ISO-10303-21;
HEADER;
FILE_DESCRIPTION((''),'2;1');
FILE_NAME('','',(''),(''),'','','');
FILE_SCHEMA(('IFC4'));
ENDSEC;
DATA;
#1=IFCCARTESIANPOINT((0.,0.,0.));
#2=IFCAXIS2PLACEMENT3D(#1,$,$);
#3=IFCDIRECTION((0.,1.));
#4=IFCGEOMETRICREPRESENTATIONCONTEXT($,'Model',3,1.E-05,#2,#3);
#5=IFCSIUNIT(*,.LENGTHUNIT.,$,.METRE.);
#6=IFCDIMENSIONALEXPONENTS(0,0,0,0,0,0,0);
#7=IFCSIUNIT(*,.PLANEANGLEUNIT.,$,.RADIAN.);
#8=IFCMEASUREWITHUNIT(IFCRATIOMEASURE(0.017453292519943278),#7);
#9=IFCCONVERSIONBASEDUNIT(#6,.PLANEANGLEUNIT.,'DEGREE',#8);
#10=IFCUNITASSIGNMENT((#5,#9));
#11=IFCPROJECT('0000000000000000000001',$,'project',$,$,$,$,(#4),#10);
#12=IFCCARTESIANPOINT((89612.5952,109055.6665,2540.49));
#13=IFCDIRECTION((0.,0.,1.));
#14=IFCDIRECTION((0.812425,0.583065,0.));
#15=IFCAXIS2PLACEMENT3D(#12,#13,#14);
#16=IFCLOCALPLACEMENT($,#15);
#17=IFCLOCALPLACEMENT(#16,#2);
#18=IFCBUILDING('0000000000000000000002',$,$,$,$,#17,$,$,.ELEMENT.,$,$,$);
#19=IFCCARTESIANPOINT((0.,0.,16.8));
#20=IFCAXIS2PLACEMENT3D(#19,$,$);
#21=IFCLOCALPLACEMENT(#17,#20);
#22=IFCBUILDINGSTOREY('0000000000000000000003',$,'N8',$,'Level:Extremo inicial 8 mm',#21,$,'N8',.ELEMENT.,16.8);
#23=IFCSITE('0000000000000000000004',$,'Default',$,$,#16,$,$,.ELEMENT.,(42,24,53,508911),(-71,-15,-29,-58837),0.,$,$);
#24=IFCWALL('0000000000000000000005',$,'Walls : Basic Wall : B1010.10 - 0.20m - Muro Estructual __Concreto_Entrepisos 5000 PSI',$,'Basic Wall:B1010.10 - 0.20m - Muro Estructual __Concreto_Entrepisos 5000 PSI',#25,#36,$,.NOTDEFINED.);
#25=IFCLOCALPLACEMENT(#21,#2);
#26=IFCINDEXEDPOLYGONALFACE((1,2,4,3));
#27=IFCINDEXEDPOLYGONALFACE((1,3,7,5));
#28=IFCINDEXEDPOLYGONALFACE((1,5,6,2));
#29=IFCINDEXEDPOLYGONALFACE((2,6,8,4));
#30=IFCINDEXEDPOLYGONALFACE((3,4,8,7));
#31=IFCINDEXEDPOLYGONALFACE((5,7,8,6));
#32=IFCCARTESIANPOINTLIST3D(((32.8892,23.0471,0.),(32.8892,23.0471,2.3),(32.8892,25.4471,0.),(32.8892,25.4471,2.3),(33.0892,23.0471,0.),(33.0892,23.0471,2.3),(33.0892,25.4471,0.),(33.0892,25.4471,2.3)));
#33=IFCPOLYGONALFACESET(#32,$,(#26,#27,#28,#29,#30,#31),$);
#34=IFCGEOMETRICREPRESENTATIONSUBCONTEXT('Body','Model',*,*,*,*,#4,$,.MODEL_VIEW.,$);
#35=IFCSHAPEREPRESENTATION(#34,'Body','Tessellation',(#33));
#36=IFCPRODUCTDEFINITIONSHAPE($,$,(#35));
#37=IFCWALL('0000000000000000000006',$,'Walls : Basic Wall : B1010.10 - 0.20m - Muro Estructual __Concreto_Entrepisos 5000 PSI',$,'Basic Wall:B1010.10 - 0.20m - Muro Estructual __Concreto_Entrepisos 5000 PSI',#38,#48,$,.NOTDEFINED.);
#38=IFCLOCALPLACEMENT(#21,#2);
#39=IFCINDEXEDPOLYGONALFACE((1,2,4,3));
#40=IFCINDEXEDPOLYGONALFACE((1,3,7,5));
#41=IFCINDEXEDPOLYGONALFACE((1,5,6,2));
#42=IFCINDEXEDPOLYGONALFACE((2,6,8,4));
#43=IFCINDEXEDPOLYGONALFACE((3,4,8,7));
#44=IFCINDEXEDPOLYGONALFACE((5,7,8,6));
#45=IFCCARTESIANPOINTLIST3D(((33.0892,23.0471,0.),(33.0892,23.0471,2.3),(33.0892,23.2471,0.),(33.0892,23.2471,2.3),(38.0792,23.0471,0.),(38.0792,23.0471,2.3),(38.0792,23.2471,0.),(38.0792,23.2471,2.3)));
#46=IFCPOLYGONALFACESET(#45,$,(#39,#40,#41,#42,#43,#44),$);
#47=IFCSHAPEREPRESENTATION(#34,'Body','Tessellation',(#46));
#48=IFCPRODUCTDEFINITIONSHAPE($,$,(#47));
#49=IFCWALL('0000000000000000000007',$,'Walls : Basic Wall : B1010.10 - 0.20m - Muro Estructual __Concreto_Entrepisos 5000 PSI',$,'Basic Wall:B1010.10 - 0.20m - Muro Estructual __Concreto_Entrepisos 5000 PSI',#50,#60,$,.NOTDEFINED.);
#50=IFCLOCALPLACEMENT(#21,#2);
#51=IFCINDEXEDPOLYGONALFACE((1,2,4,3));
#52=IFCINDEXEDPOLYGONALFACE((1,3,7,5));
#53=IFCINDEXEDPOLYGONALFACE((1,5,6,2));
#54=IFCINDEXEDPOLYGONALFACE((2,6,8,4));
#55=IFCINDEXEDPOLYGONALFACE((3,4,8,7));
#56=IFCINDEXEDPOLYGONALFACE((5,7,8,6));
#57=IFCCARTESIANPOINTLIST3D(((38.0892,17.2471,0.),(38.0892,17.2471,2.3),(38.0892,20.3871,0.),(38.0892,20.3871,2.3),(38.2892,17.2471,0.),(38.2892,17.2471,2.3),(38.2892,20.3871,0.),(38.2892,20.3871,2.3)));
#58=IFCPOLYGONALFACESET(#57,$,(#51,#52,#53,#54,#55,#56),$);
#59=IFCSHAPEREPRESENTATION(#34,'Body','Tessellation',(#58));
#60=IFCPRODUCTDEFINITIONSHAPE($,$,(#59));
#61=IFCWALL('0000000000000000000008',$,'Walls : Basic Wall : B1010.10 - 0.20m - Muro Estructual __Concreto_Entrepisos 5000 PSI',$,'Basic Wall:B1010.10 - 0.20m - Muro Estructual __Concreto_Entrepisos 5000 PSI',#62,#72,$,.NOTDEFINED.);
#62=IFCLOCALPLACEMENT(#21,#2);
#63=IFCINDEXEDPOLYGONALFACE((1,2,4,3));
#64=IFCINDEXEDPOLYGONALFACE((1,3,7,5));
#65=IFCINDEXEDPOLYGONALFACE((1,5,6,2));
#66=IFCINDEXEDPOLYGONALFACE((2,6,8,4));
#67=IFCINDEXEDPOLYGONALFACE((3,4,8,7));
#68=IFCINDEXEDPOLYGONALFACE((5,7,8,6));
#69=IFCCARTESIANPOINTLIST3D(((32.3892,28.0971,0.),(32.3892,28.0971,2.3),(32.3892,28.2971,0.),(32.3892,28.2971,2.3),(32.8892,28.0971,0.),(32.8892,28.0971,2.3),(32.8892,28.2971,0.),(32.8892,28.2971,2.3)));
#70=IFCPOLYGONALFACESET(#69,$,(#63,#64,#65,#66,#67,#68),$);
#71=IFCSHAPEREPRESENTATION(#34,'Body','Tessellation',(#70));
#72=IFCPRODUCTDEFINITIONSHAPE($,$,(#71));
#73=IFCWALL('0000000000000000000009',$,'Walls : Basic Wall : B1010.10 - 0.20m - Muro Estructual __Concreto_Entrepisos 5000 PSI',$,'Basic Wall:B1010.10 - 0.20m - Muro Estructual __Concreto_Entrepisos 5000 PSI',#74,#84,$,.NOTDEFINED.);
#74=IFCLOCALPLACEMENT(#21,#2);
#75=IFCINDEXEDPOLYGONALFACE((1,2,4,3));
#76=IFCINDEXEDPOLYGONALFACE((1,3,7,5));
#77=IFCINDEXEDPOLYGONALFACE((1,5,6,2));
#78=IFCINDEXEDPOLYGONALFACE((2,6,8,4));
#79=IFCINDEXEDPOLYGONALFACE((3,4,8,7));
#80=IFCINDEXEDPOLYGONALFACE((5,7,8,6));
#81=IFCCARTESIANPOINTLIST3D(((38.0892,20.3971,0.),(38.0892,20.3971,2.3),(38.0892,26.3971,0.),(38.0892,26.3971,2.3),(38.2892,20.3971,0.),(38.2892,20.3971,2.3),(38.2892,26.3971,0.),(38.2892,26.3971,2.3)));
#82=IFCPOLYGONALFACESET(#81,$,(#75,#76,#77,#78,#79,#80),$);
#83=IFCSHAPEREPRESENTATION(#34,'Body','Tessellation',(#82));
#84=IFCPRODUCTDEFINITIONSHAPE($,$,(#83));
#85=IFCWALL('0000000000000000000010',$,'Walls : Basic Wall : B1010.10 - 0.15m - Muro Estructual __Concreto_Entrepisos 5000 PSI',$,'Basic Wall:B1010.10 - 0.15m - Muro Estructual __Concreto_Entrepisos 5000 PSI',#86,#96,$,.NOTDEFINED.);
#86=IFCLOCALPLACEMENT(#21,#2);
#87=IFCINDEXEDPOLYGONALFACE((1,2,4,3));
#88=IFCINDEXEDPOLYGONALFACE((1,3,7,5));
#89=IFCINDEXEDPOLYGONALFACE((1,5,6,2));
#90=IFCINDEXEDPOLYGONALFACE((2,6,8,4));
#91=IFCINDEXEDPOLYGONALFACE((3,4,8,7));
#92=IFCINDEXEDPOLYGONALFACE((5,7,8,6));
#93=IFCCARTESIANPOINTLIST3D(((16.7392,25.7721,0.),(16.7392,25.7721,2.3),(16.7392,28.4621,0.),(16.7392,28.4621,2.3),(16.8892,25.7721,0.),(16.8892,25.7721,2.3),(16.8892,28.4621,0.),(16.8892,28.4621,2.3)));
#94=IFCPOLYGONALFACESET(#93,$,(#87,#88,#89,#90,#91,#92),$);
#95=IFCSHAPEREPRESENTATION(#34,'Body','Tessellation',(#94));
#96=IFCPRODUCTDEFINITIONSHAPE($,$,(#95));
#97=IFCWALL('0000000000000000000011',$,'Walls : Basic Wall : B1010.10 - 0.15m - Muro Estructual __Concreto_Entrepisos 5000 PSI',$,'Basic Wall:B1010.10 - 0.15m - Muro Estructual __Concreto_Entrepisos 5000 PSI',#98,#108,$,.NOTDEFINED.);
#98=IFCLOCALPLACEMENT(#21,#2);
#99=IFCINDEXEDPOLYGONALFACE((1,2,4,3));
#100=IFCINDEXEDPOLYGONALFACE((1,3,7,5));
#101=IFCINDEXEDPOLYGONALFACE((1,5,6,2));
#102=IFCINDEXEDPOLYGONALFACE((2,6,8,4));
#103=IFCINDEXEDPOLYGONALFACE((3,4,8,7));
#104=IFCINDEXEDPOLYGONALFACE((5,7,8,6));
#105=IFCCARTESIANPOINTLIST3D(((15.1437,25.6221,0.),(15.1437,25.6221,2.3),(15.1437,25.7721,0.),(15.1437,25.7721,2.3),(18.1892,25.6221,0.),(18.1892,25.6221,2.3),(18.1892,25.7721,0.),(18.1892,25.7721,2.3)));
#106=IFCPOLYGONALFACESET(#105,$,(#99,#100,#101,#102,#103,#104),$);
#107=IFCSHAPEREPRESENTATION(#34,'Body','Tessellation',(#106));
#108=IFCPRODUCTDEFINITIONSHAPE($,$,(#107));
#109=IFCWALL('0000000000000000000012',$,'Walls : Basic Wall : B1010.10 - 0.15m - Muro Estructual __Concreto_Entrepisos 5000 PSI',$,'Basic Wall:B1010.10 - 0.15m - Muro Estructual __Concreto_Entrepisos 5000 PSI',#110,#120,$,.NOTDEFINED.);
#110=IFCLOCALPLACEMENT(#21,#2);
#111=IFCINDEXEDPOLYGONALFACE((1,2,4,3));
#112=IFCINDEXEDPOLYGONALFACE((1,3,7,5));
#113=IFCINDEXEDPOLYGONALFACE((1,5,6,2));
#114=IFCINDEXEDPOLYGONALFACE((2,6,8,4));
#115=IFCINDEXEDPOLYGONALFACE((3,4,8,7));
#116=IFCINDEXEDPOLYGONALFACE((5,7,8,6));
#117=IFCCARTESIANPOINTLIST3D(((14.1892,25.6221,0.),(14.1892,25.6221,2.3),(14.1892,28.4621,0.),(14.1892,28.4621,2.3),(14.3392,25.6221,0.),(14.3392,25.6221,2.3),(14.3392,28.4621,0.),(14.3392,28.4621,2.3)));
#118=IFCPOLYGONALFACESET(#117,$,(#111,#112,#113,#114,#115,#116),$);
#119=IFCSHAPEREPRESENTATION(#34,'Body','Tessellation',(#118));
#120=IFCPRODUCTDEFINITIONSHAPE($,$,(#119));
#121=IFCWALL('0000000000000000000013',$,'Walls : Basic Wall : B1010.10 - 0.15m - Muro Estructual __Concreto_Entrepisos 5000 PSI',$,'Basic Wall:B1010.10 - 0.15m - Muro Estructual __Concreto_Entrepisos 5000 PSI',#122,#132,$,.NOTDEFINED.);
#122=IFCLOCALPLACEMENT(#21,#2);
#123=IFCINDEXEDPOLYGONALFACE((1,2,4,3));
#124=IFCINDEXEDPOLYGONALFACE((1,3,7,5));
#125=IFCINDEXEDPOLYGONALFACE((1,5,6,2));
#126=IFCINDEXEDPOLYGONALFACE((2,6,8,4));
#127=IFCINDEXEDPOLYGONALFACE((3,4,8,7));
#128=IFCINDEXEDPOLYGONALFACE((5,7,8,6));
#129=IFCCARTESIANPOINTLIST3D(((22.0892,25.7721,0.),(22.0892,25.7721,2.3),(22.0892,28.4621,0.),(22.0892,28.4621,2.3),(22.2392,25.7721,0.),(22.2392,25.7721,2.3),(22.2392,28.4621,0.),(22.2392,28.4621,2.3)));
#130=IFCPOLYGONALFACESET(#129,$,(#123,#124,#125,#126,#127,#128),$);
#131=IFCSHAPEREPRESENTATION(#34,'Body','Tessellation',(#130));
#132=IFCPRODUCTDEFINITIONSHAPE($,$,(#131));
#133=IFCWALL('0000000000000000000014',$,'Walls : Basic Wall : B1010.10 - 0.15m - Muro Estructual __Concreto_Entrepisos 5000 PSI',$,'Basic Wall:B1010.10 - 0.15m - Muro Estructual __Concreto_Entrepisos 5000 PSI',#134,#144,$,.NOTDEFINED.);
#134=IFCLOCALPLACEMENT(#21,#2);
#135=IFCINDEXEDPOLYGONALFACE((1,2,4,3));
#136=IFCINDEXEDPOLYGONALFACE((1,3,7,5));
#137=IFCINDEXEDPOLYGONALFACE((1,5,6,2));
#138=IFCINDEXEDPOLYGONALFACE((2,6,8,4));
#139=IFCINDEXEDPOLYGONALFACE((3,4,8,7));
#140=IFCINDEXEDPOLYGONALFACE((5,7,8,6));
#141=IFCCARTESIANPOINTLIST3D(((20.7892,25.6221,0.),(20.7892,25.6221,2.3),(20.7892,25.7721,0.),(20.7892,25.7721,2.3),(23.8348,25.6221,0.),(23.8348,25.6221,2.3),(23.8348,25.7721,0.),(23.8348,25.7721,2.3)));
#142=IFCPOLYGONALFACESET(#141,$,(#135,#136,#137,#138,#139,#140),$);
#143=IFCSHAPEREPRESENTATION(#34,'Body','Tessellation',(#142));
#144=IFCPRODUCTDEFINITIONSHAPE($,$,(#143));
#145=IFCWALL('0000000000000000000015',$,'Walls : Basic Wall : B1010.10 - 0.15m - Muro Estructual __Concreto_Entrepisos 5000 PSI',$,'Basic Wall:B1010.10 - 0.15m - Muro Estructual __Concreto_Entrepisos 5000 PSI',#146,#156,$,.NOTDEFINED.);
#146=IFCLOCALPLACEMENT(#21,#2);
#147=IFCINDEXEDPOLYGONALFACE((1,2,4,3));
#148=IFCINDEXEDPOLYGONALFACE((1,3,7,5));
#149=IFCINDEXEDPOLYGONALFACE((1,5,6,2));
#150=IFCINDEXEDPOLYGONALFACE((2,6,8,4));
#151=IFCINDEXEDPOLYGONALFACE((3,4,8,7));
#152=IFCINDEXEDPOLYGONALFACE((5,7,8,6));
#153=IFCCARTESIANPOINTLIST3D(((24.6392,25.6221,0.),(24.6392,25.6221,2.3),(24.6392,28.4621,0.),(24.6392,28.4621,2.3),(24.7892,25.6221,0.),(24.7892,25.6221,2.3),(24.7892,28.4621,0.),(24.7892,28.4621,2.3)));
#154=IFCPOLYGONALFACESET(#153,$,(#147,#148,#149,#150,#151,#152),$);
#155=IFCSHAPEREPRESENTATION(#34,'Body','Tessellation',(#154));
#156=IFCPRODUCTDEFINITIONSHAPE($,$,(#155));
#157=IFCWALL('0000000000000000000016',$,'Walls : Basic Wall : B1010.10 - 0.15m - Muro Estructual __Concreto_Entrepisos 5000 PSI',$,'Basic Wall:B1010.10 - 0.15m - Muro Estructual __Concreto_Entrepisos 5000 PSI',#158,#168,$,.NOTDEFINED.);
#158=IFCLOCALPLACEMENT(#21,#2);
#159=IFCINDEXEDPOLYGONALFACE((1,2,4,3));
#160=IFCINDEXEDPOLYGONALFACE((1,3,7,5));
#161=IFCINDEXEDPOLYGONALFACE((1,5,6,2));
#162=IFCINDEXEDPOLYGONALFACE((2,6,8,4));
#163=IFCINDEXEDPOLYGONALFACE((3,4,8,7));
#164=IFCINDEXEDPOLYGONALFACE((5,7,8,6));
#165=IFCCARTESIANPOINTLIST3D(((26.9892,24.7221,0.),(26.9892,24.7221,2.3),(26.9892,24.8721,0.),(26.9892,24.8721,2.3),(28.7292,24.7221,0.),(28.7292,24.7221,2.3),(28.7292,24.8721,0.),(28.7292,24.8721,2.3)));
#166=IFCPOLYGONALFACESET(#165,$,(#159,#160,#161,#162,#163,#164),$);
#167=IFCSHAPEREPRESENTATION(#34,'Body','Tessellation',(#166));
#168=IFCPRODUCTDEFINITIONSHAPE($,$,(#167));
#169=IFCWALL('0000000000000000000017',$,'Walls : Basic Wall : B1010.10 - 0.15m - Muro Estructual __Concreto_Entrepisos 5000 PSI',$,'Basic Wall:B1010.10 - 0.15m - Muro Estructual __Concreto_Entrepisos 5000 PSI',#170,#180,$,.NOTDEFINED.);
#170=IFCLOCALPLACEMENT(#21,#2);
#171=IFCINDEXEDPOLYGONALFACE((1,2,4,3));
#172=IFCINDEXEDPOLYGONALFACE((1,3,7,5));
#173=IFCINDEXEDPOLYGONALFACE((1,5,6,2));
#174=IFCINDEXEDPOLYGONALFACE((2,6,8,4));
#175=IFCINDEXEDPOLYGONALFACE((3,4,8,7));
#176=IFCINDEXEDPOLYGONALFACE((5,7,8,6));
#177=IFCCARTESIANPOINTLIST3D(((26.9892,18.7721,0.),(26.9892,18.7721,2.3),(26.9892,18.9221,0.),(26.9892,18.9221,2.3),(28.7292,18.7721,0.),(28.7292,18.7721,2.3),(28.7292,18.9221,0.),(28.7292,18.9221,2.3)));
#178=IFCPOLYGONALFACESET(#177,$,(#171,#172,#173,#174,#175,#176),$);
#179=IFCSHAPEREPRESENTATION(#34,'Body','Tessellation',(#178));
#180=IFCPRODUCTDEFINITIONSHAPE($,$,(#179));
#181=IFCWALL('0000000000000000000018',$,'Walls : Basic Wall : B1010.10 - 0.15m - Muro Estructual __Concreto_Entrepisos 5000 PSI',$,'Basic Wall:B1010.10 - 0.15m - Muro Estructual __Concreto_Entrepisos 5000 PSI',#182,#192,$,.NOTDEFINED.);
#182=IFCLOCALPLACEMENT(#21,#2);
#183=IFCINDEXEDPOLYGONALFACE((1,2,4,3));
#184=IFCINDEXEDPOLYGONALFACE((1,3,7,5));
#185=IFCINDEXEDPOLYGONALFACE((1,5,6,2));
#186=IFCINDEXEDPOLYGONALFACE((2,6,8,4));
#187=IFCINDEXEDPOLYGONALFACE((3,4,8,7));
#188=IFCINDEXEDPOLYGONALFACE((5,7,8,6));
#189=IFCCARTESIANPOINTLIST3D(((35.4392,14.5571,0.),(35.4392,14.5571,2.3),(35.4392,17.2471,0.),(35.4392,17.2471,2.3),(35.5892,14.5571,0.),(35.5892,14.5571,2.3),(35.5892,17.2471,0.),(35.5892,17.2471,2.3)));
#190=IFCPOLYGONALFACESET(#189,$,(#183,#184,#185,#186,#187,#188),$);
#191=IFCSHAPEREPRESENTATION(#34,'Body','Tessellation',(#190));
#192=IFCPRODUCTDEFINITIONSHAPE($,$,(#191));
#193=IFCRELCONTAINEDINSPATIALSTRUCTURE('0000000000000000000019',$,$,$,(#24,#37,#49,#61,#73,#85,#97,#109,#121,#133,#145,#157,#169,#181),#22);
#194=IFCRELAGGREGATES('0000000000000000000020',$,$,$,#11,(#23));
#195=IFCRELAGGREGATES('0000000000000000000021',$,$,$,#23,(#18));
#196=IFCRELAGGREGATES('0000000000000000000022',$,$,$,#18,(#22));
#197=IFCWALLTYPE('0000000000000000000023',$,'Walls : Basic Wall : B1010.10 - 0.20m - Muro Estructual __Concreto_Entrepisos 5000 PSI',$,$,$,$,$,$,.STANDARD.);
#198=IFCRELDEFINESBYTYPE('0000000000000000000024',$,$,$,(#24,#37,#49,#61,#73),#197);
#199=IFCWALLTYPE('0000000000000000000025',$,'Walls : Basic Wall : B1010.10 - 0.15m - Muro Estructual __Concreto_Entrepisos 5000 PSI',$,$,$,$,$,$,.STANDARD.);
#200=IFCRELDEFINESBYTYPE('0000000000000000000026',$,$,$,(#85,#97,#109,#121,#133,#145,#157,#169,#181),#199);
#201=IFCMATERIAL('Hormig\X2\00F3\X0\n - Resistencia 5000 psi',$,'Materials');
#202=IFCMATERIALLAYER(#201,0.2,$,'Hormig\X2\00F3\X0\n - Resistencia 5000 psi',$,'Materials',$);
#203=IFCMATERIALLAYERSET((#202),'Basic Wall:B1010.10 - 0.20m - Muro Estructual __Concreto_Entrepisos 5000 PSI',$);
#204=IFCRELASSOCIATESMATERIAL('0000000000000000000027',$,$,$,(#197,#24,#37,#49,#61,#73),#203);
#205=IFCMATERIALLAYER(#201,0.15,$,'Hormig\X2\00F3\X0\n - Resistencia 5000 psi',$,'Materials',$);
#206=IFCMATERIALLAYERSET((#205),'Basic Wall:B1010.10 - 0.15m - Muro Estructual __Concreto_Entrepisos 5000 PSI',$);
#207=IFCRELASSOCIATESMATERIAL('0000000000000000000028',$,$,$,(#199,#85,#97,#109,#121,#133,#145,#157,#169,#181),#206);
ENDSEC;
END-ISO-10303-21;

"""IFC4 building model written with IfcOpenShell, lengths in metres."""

from ifc_helpers import new_model, entity, si_unit, converted_unit, direction, frame, frame_2d, origin, place, context, subcontext, project, spatial, rectangle, extrude, material, layer, layer_set, layer_usage, type_object, element, save


model = new_model("IFC4")

# Units and contexts
model_context = context("Model", 3, precision=1e-05, world=origin(), true_north=direction((0.0, 1.0)))
body_context = subcontext(model_context, "Body", "Model", "MODEL_VIEW")
ifc_project = project(units=[si_unit("LENGTHUNIT", "METRE"), converted_unit("PLANEANGLEUNIT", "DEGREE", entity("IfcRatioMeasure", 0.017453292519943278), si_unit("PLANEANGLEUNIT", "RADIAN"), dimensions=[0, 0, 0, 0, 0, 0, 0])], contexts=[model_context])

# Site, building, storey
site_placement = place(None, frame((89612.5952, 109055.6665, 2540.49), z_axis=(0.0, 0.0, 1.0), x_axis=(0.812425, 0.583065, 0.0)))
site = spatial("IfcSite", under=ifc_project, at=site_placement, Name="Default", CompositionType="ELEMENT", RefLatitude=(42, 24, 53, 508911), RefLongitude=(-71, -15, -29, -58837), RefElevation=0.0)
building_placement = place(site_placement, origin())
building = spatial("IfcBuilding", under=site, at=building_placement, CompositionType="ELEMENT")
storey_placement = place(building_placement, frame((0.0, 0.0, 16.8)))
storey = spatial("IfcBuildingStorey", under=building, at=storey_placement, Name="N8", ObjectType="Level:Extremo inicial 8 mm", LongName="N8", CompositionType="ELEMENT", Elevation=16.8)

# Walls
ifc_material = material(Name="Hormigón - Resistencia 5000 psi", Category="Materials")
ifc_layer_1 = layer(ifc_material, 0.2, Name="Hormigón - Resistencia 5000 psi", Category="Materials")
ifc_layer_set_1 = layer_set([ifc_layer_1], Name="Basic Wall:B1010.10 - 0.20m - Muro Estructual __Concreto_Entrepisos 5000 PSI")
wall_type_1 = type_object("IfcWallType", Name="Walls : Basic Wall : B1010.10 - 0.20m - Muro Estructual __Concreto_Entrepisos 5000 PSI", PredefinedType="STANDARD", material=ifc_layer_set_1)
ifc_layer_usage_1 = layer_usage(ifc_layer_set_1, "AXIS2", "POSITIVE", -0.1)
wall_1_placement = place(storey_placement, frame((32.9892, 25.4471, 0.0), z_axis=(0.0, 0.0, 1.0), x_axis=(0.0, -1.0, 0.0)))
element("IfcWall", 1, at=wall_1_placement, inside=storey, type_object=wall_type_1, material=ifc_layer_usage_1, Name="Walls : Basic Wall : B1010.10 - 0.20m - Muro Estructual __Concreto_Entrepisos 5000 PSI", ObjectType="Basic Wall:B1010.10 - 0.20m - Muro Estructual __Concreto_Entrepisos 5000 PSI", PredefinedType="NOTDEFINED", context=body_context, shape_type="SweptSolid", body=[
    extrude(rectangle(XDim=2.4, YDim=0.2, at=frame_2d((1.2, 0.0), x_axis=(-1.0, 0.0))), origin(), (0.0, 0.0, 1.0), 2.3),
])
ifc_layer_usage_2 = layer_usage(ifc_layer_set_1, "AXIS2", "POSITIVE", -0.1)
wall_2_placement = place(storey_placement, frame((33.0892, 23.1471, 0.0)))
element("IfcWall", 2, at=wall_2_placement, inside=storey, type_object=wall_type_1, material=ifc_layer_usage_2, Name="Walls : Basic Wall : B1010.10 - 0.20m - Muro Estructual __Concreto_Entrepisos 5000 PSI", ObjectType="Basic Wall:B1010.10 - 0.20m - Muro Estructual __Concreto_Entrepisos 5000 PSI", PredefinedType="NOTDEFINED", context=body_context, shape_type="SweptSolid", body=[
    extrude(rectangle(XDim=4.99, YDim=0.2, at=frame_2d((2.495, 0.0), x_axis=(-1.0, 0.0))), origin(), (0.0, 0.0, 1.0), 2.3),
])
ifc_layer_usage_3 = layer_usage(ifc_layer_set_1, "AXIS2", "POSITIVE", -0.1)
wall_3_placement = place(storey_placement, frame((38.1892, 17.2471, 0.0), z_axis=(0.0, 0.0, 1.0), x_axis=(0.0, 1.0, 0.0)))
element("IfcWall", 3, at=wall_3_placement, inside=storey, type_object=wall_type_1, material=ifc_layer_usage_3, Name="Walls : Basic Wall : B1010.10 - 0.20m - Muro Estructual __Concreto_Entrepisos 5000 PSI", ObjectType="Basic Wall:B1010.10 - 0.20m - Muro Estructual __Concreto_Entrepisos 5000 PSI", PredefinedType="NOTDEFINED", context=body_context, shape_type="SweptSolid", body=[
    extrude(rectangle(XDim=3.14, YDim=0.2, at=frame_2d((1.57, 0.0), x_axis=(-1.0, 0.0))), origin(), (0.0, 0.0, 1.0), 2.3),
])
ifc_layer_usage_4 = layer_usage(ifc_layer_set_1, "AXIS2", "POSITIVE", -0.1)
wall_4_placement = place(storey_placement, frame((32.3892, 28.1971, 0.0)))
element("IfcWall", 4, at=wall_4_placement, inside=storey, type_object=wall_type_1, material=ifc_layer_usage_4, Name="Walls : Basic Wall : B1010.10 - 0.20m - Muro Estructual __Concreto_Entrepisos 5000 PSI", ObjectType="Basic Wall:B1010.10 - 0.20m - Muro Estructual __Concreto_Entrepisos 5000 PSI", PredefinedType="NOTDEFINED", context=body_context, shape_type="SweptSolid", body=[
    extrude(rectangle(XDim=0.5, YDim=0.2, at=frame_2d((0.25, 0.0), x_axis=(-1.0, 0.0))), origin(), (0.0, 0.0, 1.0), 2.3),
])
ifc_layer_usage_5 = layer_usage(ifc_layer_set_1, "AXIS2", "POSITIVE", -0.1)
wall_5_placement = place(storey_placement, frame((38.1892, 20.3971, 0.0), z_axis=(0.0, 0.0, 1.0), x_axis=(0.0, 1.0, 0.0)))
element("IfcWall", 5, at=wall_5_placement, inside=storey, type_object=wall_type_1, material=ifc_layer_usage_5, Name="Walls : Basic Wall : B1010.10 - 0.20m - Muro Estructual __Concreto_Entrepisos 5000 PSI", ObjectType="Basic Wall:B1010.10 - 0.20m - Muro Estructual __Concreto_Entrepisos 5000 PSI", PredefinedType="NOTDEFINED", context=body_context, shape_type="SweptSolid", body=[
    extrude(rectangle(XDim=6.0, YDim=0.2, at=frame_2d((3.0, 0.0), x_axis=(-1.0, 0.0))), origin(), (0.0, 0.0, 1.0), 2.3),
])
ifc_layer_2 = layer(ifc_material, 0.15, Name="Hormigón - Resistencia 5000 psi", Category="Materials")
ifc_layer_set_2 = layer_set([ifc_layer_2], Name="Basic Wall:B1010.10 - 0.15m - Muro Estructual __Concreto_Entrepisos 5000 PSI")
ifc_layer_usage_6 = layer_usage(ifc_layer_set_2, "AXIS2", "POSITIVE", -0.075)
wall_type_2 = type_object("IfcWallType", Name="Walls : Basic Wall : B1010.10 - 0.15m - Muro Estructual __Concreto_Entrepisos 5000 PSI", PredefinedType="STANDARD", material=ifc_layer_set_2)
wall_6_placement = place(storey_placement, frame((16.8142, 28.4621, 0.0), z_axis=(0.0, 0.0, 1.0), x_axis=(0.0, -1.0, 0.0)))
element("IfcWall", 6, at=wall_6_placement, inside=storey, type_object=wall_type_2, material=ifc_layer_usage_6, Name="Walls : Basic Wall : B1010.10 - 0.15m - Muro Estructual __Concreto_Entrepisos 5000 PSI", ObjectType="Basic Wall:B1010.10 - 0.15m - Muro Estructual __Concreto_Entrepisos 5000 PSI", PredefinedType="NOTDEFINED", context=body_context, shape_type="SweptSolid", body=[
    extrude(rectangle(XDim=2.69, YDim=0.15, at=frame_2d((1.345, 0.0), x_axis=(-1.0, 0.0))), origin(), (0.0, 0.0, 1.0), 2.3),
])
ifc_layer_usage_7 = layer_usage(ifc_layer_set_2, "AXIS2", "POSITIVE", -0.075)
wall_7_placement = place(storey_placement, frame((18.1892, 25.6971, 0.0), z_axis=(0.0, 0.0, 1.0), x_axis=(-1.0, 0.0, 0.0)))
element("IfcWall", 7, at=wall_7_placement, inside=storey, type_object=wall_type_2, material=ifc_layer_usage_7, Name="Walls : Basic Wall : B1010.10 - 0.15m - Muro Estructual __Concreto_Entrepisos 5000 PSI", ObjectType="Basic Wall:B1010.10 - 0.15m - Muro Estructual __Concreto_Entrepisos 5000 PSI", PredefinedType="NOTDEFINED", context=body_context, shape_type="SweptSolid", body=[
    extrude(rectangle(XDim=3.0455, YDim=0.15, at=frame_2d((1.5228, 0.0), x_axis=(-1.0, 0.0))), origin(), (0.0, 0.0, 1.0), 2.3),
])
ifc_layer_usage_8 = layer_usage(ifc_layer_set_2, "AXIS2", "POSITIVE", -0.075)
wall_8_placement = place(storey_placement, frame((14.2642, 28.4621, 0.0), z_axis=(0.0, 0.0, 1.0), x_axis=(0.0, -1.0, 0.0)))
element("IfcWall", 8, at=wall_8_placement, inside=storey, type_object=wall_type_2, material=ifc_layer_usage_8, Name="Walls : Basic Wall : B1010.10 - 0.15m - Muro Estructual __Concreto_Entrepisos 5000 PSI", ObjectType="Basic Wall:B1010.10 - 0.15m - Muro Estructual __Concreto_Entrepisos 5000 PSI", PredefinedType="NOTDEFINED", context=body_context, shape_type="SweptSolid", body=[
    extrude(rectangle(XDim=2.84, YDim=0.15, at=frame_2d((1.42, 0.0), x_axis=(-1.0, 0.0))), origin(), (0.0, 0.0, 1.0), 2.3),
])
ifc_layer_usage_9 = layer_usage(ifc_layer_set_2, "AXIS2", "NEGATIVE", 0.075)
wall_9_placement = place(storey_placement, frame((22.1642, 28.4621, 0.0), z_axis=(0.0, 0.0, 1.0), x_axis=(0.0, -1.0, 0.0)))
element("IfcWall", 9, at=wall_9_placement, inside=storey, type_object=wall_type_2, material=ifc_layer_usage_9, Name="Walls : Basic Wall : B1010.10 - 0.15m - Muro Estructual __Concreto_Entrepisos 5000 PSI", ObjectType="Basic Wall:B1010.10 - 0.15m - Muro Estructual __Concreto_Entrepisos 5000 PSI", PredefinedType="NOTDEFINED", context=body_context, shape_type="SweptSolid", body=[
    extrude(rectangle(XDim=2.69, YDim=0.15, at=frame_2d((1.345, 0.0), x_axis=(-1.0, 0.0))), origin(), (0.0, 0.0, 1.0), 2.3),
])
ifc_layer_usage_10 = layer_usage(ifc_layer_set_2, "AXIS2", "NEGATIVE", 0.075)
wall_10_placement = place(storey_placement, frame((20.7892, 25.6971, 0.0)))
element("IfcWall", 10, at=wall_10_placement, inside=storey, type_object=wall_type_2, material=ifc_layer_usage_10, Name="Walls : Basic Wall : B1010.10 - 0.15m - Muro Estructual __Concreto_Entrepisos 5000 PSI", ObjectType="Basic Wall:B1010.10 - 0.15m - Muro Estructual __Concreto_Entrepisos 5000 PSI", PredefinedType="NOTDEFINED", context=body_context, shape_type="SweptSolid", body=[
    extrude(rectangle(XDim=3.0455, YDim=0.15, at=frame_2d((1.5228, 0.0), x_axis=(-1.0, 0.0))), origin(), (0.0, 0.0, 1.0), 2.3),
])
ifc_layer_usage_11 = layer_usage(ifc_layer_set_2, "AXIS2", "NEGATIVE", 0.075)
wall_11_placement = place(storey_placement, frame((24.7142, 28.4621, 0.0), z_axis=(0.0, 0.0, 1.0), x_axis=(0.0, -1.0, 0.0)))
element("IfcWall", 11, at=wall_11_placement, inside=storey, type_object=wall_type_2, material=ifc_layer_usage_11, Name="Walls : Basic Wall : B1010.10 - 0.15m - Muro Estructual __Concreto_Entrepisos 5000 PSI", ObjectType="Basic Wall:B1010.10 - 0.15m - Muro Estructual __Concreto_Entrepisos 5000 PSI", PredefinedType="NOTDEFINED", context=body_context, shape_type="SweptSolid", body=[
    extrude(rectangle(XDim=2.84, YDim=0.15, at=frame_2d((1.42, 0.0), x_axis=(-1.0, 0.0))), origin(), (0.0, 0.0, 1.0), 2.3),
])
ifc_layer_usage_12 = layer_usage(ifc_layer_set_2, "AXIS2", "NEGATIVE", 0.075)
wall_12_placement = place(storey_placement, frame((26.9892, 24.7971, 0.0)))
element("IfcWall", 12, at=wall_12_placement, inside=storey, type_object=wall_type_2, material=ifc_layer_usage_12, Name="Walls : Basic Wall : B1010.10 - 0.15m - Muro Estructual __Concreto_Entrepisos 5000 PSI", ObjectType="Basic Wall:B1010.10 - 0.15m - Muro Estructual __Concreto_Entrepisos 5000 PSI", PredefinedType="NOTDEFINED", context=body_context, shape_type="SweptSolid", body=[
    extrude(rectangle(XDim=1.74, YDim=0.15, at=frame_2d((0.87, 0.0), x_axis=(-1.0, 0.0))), origin(), (0.0, 0.0, 1.0), 2.3),
])
ifc_layer_usage_13 = layer_usage(ifc_layer_set_2, "AXIS2", "POSITIVE", -0.075)
wall_13_placement = place(storey_placement, frame((26.9892, 18.8471, 0.0)))
element("IfcWall", 13, at=wall_13_placement, inside=storey, type_object=wall_type_2, material=ifc_layer_usage_13, Name="Walls : Basic Wall : B1010.10 - 0.15m - Muro Estructual __Concreto_Entrepisos 5000 PSI", ObjectType="Basic Wall:B1010.10 - 0.15m - Muro Estructual __Concreto_Entrepisos 5000 PSI", PredefinedType="NOTDEFINED", context=body_context, shape_type="SweptSolid", body=[
    extrude(rectangle(XDim=1.74, YDim=0.15, at=frame_2d((0.87, 0.0), x_axis=(-1.0, 0.0))), origin(), (0.0, 0.0, 1.0), 2.3),
])
ifc_layer_usage_14 = layer_usage(ifc_layer_set_2, "AXIS2", "NEGATIVE", 0.075)
wall_14_placement = place(storey_placement, frame((35.5142, 14.5571, 0.0), z_axis=(0.0, 0.0, 1.0), x_axis=(0.0, 1.0, 0.0)))
element("IfcWall", 14, at=wall_14_placement, inside=storey, type_object=wall_type_2, material=ifc_layer_usage_14, Name="Walls : Basic Wall : B1010.10 - 0.15m - Muro Estructual __Concreto_Entrepisos 5000 PSI", ObjectType="Basic Wall:B1010.10 - 0.15m - Muro Estructual __Concreto_Entrepisos 5000 PSI", PredefinedType="NOTDEFINED", context=body_context, shape_type="SweptSolid", body=[
    extrude(rectangle(XDim=2.69, YDim=0.15, at=frame_2d((1.345, 0.0), x_axis=(-1.0, 0.0))), origin(), (0.0, 0.0, 1.0), 2.3),
])

save(model, "model.ifc")
